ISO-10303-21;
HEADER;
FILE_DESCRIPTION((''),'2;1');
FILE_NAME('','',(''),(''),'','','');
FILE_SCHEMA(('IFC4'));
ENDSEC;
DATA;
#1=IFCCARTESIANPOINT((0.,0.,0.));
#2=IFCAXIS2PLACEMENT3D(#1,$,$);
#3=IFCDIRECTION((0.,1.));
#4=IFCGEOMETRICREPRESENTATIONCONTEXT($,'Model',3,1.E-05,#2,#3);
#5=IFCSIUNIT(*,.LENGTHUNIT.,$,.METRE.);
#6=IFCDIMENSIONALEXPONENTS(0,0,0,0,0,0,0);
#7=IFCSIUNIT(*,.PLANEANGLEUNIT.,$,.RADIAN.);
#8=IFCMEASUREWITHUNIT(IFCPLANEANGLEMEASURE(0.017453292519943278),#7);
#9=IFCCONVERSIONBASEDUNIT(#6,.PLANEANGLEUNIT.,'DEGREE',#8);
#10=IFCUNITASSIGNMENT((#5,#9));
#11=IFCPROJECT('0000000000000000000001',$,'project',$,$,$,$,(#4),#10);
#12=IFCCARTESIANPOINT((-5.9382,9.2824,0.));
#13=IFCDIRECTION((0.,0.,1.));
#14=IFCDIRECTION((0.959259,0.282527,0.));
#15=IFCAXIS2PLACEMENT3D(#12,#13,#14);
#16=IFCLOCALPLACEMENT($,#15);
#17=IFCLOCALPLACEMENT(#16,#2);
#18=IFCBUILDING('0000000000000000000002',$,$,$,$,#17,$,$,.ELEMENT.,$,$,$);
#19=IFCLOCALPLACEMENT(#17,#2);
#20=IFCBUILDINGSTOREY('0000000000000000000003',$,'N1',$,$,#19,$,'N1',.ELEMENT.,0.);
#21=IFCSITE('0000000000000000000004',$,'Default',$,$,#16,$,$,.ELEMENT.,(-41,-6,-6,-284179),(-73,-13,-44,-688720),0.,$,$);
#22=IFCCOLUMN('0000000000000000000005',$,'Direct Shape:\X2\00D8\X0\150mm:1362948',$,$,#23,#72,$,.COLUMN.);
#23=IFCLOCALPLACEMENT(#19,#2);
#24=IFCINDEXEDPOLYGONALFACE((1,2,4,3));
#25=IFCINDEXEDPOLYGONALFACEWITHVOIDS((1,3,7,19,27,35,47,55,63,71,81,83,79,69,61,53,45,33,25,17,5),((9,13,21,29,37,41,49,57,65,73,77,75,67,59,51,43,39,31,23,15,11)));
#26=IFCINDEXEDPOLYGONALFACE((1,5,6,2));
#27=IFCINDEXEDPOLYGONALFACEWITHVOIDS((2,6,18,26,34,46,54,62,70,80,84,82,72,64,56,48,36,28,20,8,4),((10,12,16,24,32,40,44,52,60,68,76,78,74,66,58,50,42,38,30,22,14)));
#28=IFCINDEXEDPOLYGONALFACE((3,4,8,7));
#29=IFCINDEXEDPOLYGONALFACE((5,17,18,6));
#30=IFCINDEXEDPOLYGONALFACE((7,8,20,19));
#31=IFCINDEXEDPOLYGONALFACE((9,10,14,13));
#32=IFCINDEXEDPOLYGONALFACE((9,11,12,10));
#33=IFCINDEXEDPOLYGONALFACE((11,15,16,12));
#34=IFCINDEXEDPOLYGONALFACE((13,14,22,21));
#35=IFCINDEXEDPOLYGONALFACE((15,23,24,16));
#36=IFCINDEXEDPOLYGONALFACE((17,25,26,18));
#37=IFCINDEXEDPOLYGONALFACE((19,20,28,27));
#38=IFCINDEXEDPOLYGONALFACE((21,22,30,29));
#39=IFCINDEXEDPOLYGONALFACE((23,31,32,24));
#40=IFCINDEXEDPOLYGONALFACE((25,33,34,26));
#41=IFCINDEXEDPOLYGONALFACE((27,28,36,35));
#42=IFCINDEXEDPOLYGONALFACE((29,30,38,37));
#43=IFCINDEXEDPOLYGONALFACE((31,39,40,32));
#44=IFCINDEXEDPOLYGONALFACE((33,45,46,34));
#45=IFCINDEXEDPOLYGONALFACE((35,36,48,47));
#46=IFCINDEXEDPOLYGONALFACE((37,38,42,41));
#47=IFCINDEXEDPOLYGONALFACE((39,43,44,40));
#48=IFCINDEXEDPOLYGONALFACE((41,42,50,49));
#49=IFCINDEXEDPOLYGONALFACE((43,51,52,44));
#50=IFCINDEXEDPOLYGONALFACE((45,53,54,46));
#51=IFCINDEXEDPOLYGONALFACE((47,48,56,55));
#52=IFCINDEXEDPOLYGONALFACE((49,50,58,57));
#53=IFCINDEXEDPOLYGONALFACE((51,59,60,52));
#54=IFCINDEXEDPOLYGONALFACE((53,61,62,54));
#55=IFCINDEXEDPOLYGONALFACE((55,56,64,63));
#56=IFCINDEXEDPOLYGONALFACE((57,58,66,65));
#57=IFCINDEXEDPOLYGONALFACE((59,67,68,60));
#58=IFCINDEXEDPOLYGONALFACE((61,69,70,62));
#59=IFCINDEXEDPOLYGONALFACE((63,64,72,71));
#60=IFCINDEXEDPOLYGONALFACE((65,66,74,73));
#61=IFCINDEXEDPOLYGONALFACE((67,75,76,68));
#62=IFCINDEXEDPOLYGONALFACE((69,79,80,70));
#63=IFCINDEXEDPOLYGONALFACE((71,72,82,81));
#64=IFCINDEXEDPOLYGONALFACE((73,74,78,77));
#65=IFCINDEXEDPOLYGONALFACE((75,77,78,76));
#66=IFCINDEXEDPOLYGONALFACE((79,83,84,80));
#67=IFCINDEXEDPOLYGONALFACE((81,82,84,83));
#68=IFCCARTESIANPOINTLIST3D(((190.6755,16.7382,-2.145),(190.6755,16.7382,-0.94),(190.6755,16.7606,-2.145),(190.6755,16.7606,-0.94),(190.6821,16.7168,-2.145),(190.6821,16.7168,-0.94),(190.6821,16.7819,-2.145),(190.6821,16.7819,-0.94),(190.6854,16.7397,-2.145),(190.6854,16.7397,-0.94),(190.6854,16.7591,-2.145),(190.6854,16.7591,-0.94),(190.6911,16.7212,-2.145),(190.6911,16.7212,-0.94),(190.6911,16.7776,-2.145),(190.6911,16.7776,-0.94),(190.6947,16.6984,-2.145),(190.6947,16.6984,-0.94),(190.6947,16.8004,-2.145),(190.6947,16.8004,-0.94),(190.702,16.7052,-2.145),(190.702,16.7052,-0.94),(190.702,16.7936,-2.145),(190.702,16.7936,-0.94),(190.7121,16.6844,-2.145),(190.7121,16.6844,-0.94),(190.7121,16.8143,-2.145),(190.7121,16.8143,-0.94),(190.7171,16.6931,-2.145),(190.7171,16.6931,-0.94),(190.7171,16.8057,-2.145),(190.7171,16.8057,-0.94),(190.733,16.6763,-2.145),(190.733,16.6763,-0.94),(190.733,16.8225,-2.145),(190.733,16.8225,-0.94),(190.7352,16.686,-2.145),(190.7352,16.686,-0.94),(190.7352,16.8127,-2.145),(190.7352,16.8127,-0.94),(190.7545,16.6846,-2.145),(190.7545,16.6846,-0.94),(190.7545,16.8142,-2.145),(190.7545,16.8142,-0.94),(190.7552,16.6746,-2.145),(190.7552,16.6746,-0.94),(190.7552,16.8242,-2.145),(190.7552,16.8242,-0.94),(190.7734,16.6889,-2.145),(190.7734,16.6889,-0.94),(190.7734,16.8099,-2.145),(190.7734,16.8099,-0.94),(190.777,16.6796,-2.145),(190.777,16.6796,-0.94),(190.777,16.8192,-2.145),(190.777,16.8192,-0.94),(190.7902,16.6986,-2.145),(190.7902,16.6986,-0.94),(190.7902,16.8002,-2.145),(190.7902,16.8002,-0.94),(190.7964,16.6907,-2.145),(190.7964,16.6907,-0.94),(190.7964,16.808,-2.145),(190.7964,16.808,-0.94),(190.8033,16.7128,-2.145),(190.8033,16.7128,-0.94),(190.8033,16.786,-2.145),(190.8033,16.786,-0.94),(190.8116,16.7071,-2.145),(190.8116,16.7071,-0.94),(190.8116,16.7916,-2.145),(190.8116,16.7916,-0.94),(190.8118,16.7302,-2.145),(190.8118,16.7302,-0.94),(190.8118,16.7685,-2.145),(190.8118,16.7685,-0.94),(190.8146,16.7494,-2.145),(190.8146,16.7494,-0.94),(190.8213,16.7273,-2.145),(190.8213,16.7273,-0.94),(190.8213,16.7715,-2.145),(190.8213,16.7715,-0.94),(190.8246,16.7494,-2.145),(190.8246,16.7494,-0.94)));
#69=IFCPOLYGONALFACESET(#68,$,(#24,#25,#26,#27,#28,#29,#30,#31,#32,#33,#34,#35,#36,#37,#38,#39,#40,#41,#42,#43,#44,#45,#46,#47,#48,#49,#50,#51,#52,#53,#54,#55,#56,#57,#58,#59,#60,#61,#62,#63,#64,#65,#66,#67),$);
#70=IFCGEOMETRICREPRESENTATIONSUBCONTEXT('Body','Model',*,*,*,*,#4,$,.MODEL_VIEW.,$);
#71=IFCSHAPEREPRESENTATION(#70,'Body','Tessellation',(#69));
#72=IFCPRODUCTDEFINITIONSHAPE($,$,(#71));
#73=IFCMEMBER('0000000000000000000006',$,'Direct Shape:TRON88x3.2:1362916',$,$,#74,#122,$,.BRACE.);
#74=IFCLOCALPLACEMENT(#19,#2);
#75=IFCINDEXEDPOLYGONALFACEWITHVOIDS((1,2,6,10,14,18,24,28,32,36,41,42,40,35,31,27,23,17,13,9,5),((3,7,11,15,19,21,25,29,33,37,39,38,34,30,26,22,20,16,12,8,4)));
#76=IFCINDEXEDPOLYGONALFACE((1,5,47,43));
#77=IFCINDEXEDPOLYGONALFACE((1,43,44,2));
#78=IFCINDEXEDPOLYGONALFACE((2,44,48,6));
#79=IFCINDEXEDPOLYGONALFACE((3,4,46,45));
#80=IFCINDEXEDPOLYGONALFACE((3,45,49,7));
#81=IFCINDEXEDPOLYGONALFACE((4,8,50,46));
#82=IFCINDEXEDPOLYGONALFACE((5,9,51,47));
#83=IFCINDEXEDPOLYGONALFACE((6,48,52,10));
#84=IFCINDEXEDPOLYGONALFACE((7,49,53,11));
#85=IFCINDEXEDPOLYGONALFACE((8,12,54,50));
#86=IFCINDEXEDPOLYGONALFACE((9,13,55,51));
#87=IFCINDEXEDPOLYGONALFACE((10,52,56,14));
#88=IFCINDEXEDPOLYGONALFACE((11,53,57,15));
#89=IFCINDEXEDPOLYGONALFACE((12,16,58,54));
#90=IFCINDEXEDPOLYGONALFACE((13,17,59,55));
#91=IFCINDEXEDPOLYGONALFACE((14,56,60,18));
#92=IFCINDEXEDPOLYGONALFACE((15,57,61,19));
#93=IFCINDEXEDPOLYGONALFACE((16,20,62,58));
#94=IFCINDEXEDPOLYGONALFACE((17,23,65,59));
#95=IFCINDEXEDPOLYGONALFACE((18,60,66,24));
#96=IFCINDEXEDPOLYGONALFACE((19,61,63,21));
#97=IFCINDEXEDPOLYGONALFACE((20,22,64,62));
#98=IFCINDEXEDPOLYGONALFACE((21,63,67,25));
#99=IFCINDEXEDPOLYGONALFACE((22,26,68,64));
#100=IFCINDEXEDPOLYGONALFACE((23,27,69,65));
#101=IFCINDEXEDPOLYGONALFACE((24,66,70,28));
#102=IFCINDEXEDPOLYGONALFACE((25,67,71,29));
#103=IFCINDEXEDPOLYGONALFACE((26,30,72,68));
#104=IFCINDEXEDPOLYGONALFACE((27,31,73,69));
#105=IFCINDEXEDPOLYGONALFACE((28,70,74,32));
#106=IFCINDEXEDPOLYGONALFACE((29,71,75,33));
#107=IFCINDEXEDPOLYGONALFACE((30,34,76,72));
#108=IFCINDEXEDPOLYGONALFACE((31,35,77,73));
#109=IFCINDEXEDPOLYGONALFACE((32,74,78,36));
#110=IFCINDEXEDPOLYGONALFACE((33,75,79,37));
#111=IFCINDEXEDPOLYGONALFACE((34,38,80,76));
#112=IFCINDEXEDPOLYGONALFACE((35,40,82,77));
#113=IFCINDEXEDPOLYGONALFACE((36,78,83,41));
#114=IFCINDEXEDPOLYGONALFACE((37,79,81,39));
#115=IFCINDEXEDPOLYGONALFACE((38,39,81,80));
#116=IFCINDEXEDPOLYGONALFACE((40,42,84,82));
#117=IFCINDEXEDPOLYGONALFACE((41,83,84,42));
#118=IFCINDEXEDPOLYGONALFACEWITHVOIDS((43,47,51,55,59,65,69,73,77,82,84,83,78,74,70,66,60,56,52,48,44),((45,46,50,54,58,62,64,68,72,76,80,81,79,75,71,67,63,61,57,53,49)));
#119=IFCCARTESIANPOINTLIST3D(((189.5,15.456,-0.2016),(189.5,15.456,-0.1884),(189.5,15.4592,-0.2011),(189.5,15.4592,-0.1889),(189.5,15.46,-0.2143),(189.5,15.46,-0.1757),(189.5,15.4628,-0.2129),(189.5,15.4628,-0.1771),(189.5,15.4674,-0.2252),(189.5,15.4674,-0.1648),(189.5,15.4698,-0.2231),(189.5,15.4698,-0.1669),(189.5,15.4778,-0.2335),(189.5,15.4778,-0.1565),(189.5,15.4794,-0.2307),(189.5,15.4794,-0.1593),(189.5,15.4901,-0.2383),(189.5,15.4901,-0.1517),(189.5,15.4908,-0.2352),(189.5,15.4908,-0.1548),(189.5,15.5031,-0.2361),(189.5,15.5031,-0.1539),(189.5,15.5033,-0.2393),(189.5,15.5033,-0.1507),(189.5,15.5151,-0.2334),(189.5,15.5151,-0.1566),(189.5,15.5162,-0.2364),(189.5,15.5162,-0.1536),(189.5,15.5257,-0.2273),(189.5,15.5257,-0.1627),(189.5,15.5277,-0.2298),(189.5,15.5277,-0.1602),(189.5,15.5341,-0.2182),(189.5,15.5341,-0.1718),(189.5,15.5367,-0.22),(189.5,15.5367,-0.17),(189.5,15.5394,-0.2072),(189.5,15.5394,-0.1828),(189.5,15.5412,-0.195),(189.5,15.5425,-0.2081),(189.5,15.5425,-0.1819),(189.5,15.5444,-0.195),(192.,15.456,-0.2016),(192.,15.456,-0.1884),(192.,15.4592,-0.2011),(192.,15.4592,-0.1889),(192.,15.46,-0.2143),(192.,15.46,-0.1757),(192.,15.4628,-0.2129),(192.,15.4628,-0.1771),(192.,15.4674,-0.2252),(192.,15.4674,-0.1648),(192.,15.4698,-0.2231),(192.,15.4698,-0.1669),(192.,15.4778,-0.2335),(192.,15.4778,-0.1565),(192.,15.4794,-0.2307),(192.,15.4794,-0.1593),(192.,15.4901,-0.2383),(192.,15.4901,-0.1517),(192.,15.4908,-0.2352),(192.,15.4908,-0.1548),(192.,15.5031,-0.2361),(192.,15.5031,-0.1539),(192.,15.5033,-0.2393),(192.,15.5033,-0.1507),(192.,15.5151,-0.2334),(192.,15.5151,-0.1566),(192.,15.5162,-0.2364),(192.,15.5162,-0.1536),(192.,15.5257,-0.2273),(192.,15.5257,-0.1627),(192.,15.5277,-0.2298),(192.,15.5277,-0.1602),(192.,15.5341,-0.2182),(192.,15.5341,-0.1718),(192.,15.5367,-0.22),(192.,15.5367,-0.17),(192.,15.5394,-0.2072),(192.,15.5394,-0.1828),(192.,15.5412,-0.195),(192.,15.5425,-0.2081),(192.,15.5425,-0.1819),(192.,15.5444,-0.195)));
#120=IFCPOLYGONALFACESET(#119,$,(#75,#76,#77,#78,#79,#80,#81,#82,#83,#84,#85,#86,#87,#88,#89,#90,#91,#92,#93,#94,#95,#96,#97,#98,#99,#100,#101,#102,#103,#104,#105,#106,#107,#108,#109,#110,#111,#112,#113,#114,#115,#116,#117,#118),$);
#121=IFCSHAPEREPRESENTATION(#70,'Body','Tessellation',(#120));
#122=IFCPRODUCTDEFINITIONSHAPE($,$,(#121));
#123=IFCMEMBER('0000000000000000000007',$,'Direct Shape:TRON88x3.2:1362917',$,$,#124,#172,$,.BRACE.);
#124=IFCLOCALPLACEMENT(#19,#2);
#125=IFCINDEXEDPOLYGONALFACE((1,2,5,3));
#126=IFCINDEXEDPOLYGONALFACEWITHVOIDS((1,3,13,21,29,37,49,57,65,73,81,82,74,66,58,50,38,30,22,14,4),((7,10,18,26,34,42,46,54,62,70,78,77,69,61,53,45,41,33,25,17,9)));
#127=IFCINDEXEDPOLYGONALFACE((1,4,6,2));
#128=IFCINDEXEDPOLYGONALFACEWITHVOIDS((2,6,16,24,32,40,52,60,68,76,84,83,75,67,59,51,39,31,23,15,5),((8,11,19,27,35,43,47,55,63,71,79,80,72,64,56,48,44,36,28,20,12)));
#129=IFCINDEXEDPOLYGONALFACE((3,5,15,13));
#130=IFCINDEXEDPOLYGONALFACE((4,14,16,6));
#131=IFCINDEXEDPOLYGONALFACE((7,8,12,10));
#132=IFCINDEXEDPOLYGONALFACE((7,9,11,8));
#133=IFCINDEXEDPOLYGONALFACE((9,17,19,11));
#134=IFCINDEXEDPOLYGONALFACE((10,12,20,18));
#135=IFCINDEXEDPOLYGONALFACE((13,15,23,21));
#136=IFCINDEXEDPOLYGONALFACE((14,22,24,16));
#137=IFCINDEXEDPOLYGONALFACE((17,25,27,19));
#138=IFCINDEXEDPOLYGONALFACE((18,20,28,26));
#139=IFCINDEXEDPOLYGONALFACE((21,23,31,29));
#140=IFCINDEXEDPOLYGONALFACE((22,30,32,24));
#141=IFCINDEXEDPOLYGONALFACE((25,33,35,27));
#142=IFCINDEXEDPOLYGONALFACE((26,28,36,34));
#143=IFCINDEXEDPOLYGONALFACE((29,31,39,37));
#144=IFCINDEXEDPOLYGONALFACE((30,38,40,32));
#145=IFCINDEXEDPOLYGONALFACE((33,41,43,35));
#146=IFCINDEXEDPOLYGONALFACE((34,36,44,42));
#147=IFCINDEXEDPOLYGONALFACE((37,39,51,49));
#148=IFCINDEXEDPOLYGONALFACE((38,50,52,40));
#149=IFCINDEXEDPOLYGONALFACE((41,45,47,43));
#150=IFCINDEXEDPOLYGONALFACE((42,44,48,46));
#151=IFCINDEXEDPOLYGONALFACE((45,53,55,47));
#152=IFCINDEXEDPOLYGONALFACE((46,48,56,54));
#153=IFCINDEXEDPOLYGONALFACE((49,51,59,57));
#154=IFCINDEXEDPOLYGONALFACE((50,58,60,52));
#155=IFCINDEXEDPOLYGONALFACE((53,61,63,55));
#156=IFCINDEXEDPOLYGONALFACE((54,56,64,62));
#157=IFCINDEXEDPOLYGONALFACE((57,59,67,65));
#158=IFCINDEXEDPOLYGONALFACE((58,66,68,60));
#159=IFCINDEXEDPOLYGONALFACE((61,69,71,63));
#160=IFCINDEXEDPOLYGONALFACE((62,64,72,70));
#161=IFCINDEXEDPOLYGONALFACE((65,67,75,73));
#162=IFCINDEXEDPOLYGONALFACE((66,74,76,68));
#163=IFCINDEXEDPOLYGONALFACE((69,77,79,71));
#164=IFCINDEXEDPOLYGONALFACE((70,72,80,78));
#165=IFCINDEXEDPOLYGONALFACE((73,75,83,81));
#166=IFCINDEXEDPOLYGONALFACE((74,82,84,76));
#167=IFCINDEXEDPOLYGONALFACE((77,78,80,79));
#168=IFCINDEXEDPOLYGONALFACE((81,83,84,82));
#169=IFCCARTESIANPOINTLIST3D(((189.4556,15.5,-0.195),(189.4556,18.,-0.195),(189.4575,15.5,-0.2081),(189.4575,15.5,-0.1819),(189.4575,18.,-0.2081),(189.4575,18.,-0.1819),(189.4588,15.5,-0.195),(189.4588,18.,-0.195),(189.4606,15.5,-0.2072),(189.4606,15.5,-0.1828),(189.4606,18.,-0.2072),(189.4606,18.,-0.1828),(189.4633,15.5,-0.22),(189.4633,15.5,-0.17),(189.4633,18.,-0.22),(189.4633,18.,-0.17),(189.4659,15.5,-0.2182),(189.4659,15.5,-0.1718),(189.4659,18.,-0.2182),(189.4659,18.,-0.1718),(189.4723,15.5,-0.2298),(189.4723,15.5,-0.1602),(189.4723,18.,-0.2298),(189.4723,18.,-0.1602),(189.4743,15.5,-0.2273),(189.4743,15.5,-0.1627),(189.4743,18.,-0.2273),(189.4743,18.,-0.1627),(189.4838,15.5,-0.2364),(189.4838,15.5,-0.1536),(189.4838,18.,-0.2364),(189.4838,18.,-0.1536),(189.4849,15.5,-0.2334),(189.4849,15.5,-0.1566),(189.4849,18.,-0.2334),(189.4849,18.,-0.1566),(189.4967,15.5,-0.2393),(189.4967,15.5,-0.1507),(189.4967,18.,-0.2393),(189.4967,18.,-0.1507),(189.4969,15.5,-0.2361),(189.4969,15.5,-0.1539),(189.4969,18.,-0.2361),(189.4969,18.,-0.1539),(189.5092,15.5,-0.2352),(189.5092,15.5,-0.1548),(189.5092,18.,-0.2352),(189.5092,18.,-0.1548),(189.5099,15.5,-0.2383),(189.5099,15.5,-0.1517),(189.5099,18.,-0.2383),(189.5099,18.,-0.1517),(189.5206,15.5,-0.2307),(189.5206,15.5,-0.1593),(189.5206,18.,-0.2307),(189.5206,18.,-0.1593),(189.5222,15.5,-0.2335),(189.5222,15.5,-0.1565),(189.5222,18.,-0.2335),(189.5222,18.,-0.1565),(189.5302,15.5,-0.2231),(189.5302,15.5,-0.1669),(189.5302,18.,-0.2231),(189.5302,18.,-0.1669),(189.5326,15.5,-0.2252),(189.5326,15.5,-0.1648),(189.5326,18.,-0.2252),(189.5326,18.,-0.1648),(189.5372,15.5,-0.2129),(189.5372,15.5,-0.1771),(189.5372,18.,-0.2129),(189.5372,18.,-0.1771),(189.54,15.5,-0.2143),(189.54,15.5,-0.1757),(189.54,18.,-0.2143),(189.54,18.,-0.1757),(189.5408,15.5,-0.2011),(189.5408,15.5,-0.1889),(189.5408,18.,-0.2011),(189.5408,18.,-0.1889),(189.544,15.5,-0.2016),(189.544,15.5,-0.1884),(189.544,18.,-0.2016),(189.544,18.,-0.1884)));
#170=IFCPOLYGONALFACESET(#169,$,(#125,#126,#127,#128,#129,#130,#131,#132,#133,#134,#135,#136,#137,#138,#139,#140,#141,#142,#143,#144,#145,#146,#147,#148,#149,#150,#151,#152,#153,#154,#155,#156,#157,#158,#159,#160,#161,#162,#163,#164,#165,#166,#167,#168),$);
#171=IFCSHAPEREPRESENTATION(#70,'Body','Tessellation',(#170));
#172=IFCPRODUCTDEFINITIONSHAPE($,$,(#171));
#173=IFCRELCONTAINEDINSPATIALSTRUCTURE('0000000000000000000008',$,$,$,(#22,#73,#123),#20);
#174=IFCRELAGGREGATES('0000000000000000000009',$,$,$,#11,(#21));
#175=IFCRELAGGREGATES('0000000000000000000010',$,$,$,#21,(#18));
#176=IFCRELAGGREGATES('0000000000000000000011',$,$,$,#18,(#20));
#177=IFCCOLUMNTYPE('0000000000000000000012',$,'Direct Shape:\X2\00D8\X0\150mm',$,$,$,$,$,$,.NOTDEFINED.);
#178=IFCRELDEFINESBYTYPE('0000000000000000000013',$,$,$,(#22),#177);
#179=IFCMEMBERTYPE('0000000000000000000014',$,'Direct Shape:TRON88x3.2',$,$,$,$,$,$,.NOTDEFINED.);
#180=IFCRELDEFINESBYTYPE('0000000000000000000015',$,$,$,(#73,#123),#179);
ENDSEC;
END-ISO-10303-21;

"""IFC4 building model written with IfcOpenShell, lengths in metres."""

from ifc_helpers import new_model, entity, si_unit, converted_unit, direction, frame, frame_2d, origin, origin_2d_with_axis, place, context, subcontext, project, spatial, hollow_circle, extrude, type_object, element, save


model = new_model("IFC4")

# Units and contexts
model_context = context("Model", 3, precision=1e-05, world=origin(), true_north=direction((0.0, 1.0)))
body_context = subcontext(model_context, "Body", "Model", "MODEL_VIEW")
ifc_project = project(units=[si_unit("LENGTHUNIT", "METRE"), converted_unit("PLANEANGLEUNIT", "DEGREE", entity("IfcPlaneAngleMeasure", 0.017453292519943278), si_unit("PLANEANGLEUNIT", "RADIAN"), dimensions=[0, 0, 0, 0, 0, 0, 0])], contexts=[model_context])

# Site, building, storey
site_placement = place(None, frame((-5.9382, 9.2824, 0.0), z_axis=(0.0, 0.0, 1.0), x_axis=(0.959259, 0.282527, 0.0)))
site = spatial("IfcSite", under=ifc_project, at=site_placement, Name="Default", CompositionType="ELEMENT", RefLatitude=(-41, -6, -6, -284179), RefLongitude=(-73, -13, -44, -688720), RefElevation=0.0)
building_placement = place(site_placement, origin())
building = spatial("IfcBuilding", under=site, at=building_placement, CompositionType="ELEMENT")
storey_placement = place(building_placement, origin())
storey = spatial("IfcBuildingStorey", under=building, at=storey_placement, Name="N1", LongName="N1", CompositionType="ELEMENT", Elevation=0.0)

# Column
column_type = type_object("IfcColumnType", Name="Direct Shape:Ø150mm", PredefinedType="NOTDEFINED")
column_placement = place(storey_placement, origin())
element("IfcColumn", 1, at=column_placement, inside=storey, type_object=column_type, Name="Direct Shape:Ø150mm:1362948", PredefinedType="COLUMN", context=body_context, shape_type="SweptSolid", body=[
    extrude(hollow_circle(Radius=0.075, WallThickness=0.01, at=origin_2d_with_axis()), frame((190.7496, 16.7494, -2.145)), (0.0, 0.0, 1.0), 1.205),
])

# Members
member_type_1 = type_object("IfcMemberType", Name="Direct Shape:TRON88x3.2", PredefinedType="NOTDEFINED")
member_1_placement = place(storey_placement, origin())
element("IfcMember", 2, at=member_1_placement, inside=storey, type_object=member_type_1, Name="Direct Shape:TRON88x3.2:1362916", PredefinedType="BRACE", context=body_context, shape_type="SweptSolid", body=[
    extrude(hollow_circle(Radius=0.0445, WallThickness=0.0032, at=frame_2d((0.0, 0.0), x_axis=(1.0, 0.0))), frame((189.5, 15.5, -0.195), z_axis=(1.0, 0.0, 0.0), x_axis=(0.0, 1.0, 0.0)), (0.0, 0.0, 1.0), 2.5),
])
member_2_placement = place(storey_placement, origin())
element("IfcMember", 3, at=member_2_placement, inside=storey, type_object=member_type_1, Name="Direct Shape:TRON88x3.2:1362917", PredefinedType="BRACE", context=body_context, shape_type="SweptSolid", body=[
    extrude(hollow_circle(Radius=0.0445, WallThickness=0.0032, at=frame_2d((0.0, 0.0), x_axis=(1.0, 0.0))), frame((189.5, 15.5, -0.195), z_axis=(0.0, 1.0, 0.0), x_axis=(-1.0, 0.0, 0.0)), (0.0, 0.0, 1.0), 2.5),
])

save(model, "model.ifc")
